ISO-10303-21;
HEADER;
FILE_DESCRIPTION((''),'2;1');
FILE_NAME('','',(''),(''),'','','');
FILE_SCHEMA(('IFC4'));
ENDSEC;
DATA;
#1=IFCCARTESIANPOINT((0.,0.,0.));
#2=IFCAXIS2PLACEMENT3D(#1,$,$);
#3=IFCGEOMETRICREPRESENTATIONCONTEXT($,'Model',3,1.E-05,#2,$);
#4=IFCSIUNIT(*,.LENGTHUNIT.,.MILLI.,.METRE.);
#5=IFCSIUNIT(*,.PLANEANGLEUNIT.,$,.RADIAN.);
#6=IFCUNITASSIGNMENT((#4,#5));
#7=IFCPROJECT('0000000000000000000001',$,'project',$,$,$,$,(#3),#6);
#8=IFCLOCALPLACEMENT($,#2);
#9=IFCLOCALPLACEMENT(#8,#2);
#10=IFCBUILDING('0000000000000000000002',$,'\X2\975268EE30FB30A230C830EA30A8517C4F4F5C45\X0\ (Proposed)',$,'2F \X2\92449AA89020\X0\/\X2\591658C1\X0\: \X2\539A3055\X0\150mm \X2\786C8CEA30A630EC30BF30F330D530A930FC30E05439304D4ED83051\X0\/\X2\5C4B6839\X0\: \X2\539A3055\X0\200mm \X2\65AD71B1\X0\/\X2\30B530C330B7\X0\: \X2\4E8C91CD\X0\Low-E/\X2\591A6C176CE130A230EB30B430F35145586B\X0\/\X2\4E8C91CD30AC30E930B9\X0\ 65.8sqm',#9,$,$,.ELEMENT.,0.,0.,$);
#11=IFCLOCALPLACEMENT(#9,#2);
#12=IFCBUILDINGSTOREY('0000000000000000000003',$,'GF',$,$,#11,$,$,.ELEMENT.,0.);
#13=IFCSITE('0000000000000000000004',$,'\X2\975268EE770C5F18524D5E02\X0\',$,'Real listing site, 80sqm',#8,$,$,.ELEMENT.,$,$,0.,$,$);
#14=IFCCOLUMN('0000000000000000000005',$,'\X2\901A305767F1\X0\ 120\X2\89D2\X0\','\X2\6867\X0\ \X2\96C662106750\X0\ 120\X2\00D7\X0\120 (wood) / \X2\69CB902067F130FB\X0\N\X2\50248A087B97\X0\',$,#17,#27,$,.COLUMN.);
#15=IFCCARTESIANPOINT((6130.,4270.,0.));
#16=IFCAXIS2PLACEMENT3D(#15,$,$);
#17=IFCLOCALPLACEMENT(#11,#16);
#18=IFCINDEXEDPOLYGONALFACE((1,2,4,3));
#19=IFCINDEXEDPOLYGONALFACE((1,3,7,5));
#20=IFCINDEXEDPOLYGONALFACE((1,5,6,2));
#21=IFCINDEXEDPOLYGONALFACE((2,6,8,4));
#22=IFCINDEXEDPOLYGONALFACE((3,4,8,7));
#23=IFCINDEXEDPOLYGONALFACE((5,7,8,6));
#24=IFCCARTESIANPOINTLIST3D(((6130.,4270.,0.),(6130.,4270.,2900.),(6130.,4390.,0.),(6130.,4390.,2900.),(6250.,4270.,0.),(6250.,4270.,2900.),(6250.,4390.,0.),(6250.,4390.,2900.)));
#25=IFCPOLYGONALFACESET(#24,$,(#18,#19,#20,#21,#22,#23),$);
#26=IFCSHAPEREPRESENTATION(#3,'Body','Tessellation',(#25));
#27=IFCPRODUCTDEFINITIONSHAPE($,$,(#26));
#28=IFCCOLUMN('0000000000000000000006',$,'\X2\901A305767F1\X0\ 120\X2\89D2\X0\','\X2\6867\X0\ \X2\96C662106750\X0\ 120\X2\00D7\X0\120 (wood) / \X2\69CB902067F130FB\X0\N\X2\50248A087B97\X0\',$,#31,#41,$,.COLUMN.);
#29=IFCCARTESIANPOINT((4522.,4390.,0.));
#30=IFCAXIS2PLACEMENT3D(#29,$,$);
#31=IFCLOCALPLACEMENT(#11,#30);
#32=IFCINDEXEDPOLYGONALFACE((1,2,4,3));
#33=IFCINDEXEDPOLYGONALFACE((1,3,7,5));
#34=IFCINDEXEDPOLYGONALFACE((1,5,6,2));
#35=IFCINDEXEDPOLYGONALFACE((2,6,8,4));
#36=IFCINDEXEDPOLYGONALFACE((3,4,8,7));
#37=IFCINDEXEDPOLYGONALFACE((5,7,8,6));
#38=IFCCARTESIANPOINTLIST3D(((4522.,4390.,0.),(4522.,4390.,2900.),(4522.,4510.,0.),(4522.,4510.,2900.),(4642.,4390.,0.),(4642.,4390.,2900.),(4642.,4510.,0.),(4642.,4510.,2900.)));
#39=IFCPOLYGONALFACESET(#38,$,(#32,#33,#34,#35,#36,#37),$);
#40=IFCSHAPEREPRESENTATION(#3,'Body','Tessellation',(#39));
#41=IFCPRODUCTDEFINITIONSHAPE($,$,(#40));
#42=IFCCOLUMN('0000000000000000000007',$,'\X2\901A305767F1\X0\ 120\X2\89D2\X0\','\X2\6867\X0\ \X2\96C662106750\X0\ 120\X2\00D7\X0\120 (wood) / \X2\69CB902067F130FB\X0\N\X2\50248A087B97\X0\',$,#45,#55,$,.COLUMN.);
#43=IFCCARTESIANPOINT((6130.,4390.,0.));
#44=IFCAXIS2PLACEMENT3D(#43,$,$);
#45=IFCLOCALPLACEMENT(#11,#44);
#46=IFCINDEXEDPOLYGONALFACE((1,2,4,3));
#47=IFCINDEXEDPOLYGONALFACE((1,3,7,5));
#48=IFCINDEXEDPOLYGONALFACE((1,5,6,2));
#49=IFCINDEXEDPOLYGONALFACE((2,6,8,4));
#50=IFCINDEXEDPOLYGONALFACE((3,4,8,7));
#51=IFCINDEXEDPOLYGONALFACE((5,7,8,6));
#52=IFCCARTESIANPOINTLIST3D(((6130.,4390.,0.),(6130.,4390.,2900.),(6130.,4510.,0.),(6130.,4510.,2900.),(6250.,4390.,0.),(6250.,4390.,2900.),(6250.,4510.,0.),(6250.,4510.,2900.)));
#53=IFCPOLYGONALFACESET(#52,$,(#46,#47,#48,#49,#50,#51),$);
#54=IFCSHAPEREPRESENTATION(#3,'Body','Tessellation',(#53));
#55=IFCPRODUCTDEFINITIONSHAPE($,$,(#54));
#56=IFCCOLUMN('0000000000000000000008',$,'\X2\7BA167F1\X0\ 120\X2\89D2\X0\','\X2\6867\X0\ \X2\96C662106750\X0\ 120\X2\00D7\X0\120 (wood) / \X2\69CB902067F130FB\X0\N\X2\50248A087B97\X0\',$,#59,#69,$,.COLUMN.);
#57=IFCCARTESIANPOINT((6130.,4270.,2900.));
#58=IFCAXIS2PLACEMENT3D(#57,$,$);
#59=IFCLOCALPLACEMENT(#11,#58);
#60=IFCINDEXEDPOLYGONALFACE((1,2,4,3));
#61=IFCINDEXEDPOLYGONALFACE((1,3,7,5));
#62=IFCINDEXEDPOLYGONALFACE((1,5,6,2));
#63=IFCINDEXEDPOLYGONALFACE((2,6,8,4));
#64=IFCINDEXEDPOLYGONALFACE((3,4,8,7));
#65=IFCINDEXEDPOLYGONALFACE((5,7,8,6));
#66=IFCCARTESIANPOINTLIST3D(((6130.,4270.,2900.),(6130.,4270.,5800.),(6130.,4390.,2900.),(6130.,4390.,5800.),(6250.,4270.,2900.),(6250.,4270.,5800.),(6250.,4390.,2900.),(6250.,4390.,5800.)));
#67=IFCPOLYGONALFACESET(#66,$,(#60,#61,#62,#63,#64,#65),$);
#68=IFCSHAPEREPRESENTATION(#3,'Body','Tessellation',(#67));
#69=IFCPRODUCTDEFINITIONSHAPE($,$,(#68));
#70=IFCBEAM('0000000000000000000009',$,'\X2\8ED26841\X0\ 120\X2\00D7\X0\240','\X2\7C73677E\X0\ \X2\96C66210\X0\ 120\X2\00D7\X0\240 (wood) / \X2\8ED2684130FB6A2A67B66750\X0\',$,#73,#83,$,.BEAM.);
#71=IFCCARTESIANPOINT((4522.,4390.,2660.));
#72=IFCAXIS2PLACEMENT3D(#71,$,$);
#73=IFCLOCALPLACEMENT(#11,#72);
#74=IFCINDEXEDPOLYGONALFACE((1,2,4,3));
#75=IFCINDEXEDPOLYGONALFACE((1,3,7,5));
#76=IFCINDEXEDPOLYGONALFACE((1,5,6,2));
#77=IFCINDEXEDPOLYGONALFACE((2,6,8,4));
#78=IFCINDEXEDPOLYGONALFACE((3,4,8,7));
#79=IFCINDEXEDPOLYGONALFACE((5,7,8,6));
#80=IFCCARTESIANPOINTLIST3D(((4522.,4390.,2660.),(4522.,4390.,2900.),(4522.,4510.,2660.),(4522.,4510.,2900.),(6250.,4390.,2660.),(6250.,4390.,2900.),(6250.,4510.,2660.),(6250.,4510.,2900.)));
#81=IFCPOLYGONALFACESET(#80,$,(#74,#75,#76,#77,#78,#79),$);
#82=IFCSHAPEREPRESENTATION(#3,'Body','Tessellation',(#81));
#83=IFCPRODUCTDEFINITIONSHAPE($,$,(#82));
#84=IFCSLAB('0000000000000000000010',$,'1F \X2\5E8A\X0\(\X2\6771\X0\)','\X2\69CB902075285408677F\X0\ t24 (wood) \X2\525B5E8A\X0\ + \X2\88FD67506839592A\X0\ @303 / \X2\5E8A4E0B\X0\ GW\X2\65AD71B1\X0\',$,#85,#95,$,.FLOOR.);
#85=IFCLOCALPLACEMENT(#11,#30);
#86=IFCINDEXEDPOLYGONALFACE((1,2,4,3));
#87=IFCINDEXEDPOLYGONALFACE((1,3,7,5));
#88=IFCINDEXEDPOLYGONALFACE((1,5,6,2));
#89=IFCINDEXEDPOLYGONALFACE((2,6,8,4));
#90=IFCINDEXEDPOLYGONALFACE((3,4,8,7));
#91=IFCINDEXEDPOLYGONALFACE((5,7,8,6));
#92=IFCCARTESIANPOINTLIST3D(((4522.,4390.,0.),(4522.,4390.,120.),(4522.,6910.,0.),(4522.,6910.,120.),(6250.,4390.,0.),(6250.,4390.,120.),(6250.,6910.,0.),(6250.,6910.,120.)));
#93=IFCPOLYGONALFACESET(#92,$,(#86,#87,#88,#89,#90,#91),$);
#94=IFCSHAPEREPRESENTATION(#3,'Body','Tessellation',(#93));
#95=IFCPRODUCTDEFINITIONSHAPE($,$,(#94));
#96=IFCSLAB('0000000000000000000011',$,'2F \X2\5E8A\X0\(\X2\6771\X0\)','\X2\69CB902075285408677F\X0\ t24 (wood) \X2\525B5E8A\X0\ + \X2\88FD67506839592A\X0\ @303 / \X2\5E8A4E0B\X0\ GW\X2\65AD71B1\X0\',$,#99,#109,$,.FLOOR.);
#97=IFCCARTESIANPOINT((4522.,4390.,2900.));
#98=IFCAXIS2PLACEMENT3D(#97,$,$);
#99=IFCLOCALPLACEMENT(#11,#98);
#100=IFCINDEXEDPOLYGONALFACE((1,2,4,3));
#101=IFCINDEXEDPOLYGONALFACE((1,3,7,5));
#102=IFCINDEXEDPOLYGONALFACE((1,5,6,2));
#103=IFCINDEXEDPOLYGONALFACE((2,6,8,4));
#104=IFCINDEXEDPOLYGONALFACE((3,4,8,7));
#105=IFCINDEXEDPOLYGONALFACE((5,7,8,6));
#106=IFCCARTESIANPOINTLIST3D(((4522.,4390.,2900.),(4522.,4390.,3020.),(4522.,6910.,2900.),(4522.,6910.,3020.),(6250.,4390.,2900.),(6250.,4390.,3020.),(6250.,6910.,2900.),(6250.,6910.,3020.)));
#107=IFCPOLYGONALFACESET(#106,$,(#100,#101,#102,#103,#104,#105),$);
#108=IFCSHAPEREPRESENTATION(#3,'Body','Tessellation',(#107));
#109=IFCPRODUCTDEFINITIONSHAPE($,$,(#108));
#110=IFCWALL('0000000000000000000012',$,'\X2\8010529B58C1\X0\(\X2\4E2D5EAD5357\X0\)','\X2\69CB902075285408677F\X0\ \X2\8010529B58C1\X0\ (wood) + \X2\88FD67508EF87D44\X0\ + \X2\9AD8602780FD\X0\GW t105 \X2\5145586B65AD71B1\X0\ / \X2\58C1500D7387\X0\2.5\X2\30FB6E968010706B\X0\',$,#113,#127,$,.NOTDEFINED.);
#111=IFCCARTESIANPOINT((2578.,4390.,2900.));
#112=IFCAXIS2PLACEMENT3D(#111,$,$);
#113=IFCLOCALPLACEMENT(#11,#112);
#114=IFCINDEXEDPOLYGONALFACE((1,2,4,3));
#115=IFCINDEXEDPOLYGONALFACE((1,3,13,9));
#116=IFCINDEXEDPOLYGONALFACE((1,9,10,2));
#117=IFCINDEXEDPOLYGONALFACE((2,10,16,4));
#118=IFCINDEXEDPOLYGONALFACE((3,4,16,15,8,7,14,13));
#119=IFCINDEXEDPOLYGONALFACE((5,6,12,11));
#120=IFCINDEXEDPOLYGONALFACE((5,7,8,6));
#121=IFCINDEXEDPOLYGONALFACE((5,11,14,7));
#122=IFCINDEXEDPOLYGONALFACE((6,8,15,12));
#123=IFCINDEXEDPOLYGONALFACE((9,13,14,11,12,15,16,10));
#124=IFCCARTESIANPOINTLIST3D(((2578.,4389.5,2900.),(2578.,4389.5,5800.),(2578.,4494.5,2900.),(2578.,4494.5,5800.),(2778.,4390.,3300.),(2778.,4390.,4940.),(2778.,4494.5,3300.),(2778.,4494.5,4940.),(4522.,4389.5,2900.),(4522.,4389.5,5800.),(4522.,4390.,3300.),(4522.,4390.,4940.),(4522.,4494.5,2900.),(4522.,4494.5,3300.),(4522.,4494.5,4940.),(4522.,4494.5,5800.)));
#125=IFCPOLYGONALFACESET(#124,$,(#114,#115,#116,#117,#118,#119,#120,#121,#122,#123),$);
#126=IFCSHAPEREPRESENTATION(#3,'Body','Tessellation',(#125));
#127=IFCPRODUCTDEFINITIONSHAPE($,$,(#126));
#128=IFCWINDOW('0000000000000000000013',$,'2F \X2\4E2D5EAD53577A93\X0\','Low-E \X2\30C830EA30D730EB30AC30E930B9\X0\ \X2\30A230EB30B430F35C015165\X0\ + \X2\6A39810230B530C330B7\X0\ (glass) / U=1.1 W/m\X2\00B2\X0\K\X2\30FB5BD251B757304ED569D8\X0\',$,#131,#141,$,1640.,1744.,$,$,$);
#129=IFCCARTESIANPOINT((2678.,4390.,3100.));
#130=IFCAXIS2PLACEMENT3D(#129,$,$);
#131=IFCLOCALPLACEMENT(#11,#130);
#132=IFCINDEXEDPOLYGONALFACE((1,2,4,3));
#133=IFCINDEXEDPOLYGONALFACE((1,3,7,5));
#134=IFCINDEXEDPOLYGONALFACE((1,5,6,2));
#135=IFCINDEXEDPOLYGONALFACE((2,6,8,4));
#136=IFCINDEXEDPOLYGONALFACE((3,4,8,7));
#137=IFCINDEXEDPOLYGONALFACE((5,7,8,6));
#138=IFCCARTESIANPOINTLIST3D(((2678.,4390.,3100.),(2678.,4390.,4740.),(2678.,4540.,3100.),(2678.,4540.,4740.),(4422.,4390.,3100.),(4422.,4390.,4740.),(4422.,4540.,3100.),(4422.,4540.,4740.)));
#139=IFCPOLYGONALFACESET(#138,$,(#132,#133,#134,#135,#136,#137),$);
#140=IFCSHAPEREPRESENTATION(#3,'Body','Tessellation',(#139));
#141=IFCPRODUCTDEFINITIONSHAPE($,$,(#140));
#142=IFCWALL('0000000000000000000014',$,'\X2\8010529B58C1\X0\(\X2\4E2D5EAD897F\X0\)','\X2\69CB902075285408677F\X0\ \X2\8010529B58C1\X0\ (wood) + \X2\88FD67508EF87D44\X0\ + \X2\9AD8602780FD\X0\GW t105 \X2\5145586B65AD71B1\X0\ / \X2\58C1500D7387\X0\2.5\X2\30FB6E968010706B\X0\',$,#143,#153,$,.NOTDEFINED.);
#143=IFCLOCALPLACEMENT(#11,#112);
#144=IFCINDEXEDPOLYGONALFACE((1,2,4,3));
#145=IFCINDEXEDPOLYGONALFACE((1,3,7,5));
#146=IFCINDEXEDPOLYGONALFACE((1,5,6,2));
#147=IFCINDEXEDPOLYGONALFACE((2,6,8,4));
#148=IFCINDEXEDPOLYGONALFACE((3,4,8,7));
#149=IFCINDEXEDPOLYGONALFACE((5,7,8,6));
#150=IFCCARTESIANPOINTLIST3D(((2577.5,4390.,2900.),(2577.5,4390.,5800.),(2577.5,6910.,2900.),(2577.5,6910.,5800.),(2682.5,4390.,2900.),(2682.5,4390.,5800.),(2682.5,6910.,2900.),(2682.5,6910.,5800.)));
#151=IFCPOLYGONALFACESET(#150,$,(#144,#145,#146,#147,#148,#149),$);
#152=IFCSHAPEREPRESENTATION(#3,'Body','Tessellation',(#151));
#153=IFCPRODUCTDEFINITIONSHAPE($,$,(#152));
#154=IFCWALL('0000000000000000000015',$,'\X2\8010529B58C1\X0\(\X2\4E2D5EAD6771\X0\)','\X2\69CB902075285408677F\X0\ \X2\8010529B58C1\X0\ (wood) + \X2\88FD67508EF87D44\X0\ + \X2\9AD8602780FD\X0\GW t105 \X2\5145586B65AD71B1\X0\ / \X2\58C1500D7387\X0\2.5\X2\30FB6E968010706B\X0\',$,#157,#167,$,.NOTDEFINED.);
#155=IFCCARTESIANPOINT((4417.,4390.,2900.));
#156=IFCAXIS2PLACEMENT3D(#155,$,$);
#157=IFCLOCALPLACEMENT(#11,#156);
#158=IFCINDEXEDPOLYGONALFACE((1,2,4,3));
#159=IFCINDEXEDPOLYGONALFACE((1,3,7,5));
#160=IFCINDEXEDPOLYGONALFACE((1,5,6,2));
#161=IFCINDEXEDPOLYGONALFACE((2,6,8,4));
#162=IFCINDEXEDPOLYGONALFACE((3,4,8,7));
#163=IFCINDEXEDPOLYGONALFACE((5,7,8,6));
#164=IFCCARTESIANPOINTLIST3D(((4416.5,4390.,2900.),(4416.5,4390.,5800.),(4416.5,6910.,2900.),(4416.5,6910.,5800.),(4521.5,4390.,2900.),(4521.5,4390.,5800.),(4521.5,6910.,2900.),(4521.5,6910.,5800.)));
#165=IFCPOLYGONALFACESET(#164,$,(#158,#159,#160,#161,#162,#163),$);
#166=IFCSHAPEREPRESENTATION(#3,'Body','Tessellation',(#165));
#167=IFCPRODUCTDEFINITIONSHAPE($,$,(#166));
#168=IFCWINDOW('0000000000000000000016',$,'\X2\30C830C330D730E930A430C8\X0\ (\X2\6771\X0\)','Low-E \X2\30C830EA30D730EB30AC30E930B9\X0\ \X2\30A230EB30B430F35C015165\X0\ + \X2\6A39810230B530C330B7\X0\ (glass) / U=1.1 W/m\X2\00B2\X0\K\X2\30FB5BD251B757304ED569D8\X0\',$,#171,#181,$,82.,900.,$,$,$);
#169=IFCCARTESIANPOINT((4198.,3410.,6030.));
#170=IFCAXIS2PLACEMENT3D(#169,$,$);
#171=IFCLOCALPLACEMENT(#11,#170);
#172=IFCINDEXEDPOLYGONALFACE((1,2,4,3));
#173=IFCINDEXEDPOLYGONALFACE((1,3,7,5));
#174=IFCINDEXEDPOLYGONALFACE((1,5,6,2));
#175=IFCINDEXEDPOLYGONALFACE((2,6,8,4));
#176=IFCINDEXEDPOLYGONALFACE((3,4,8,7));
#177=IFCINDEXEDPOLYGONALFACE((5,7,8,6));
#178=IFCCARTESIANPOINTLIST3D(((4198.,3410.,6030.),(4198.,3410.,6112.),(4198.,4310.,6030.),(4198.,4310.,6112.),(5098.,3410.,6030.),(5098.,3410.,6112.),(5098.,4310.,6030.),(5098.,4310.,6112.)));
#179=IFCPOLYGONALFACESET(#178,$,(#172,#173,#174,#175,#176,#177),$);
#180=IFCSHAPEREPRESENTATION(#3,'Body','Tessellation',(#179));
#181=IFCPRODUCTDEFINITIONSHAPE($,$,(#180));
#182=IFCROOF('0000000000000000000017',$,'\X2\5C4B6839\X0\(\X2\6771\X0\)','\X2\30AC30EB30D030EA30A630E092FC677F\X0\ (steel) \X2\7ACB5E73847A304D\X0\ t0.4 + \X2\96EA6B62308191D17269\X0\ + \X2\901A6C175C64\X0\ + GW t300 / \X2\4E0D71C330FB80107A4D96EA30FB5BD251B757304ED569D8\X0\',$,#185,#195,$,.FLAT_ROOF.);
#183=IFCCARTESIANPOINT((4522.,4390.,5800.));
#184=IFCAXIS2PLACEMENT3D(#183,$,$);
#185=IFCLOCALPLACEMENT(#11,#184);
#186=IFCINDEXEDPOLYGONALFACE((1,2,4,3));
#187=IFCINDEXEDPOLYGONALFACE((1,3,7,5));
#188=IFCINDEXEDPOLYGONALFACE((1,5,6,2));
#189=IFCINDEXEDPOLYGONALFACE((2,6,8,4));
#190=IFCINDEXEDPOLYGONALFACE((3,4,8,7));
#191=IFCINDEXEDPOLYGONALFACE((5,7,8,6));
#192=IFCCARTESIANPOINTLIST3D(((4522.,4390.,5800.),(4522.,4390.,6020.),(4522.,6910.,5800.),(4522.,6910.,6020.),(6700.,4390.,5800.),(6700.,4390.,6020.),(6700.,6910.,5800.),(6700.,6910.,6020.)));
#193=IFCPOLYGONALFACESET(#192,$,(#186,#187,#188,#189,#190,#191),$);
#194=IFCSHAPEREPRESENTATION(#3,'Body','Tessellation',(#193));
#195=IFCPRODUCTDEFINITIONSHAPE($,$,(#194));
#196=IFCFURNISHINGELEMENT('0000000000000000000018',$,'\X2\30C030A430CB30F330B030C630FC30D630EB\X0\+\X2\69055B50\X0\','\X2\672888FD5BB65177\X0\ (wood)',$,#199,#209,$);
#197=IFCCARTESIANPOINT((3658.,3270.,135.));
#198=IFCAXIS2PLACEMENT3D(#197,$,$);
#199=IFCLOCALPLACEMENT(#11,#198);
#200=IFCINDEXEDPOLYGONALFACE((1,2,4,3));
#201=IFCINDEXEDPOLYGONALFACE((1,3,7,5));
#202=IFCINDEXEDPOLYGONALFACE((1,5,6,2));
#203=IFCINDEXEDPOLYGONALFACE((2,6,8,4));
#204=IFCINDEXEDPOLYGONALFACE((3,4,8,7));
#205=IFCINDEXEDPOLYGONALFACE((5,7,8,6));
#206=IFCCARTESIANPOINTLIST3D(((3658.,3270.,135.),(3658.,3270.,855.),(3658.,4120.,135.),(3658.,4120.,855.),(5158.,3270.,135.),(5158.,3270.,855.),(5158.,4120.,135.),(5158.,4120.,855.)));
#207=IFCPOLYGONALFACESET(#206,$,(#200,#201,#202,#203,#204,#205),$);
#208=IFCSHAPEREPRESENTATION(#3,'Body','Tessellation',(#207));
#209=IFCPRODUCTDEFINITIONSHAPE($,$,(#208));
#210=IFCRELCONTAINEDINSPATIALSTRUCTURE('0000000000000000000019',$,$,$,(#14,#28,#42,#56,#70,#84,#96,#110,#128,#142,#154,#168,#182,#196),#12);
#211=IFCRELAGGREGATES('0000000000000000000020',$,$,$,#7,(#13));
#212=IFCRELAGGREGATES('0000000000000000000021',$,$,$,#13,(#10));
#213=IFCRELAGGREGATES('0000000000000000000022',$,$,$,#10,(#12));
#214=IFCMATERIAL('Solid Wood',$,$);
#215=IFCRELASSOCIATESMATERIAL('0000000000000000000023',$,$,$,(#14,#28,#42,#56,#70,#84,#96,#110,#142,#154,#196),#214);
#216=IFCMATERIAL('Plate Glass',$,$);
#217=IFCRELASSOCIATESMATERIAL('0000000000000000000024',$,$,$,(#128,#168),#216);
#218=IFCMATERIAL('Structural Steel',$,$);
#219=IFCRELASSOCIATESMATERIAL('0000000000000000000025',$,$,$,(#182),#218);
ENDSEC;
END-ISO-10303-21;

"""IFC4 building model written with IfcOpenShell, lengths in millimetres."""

from ifc_helpers import new_model, si_unit, frame, frame_2d, origin, place, context, project, spatial, rectangle, extrude, material, element, fill, save


model = new_model("IFC4")

# Units and contexts
model_context = context("Model", 3, precision=1e-05, world=origin())
ifc_project = project(units=[si_unit("LENGTHUNIT", "METRE", prefix="MILLI"), si_unit("PLANEANGLEUNIT", "RADIAN")], contexts=[model_context])

# Site, building, storey
site_placement = place(None, origin())
site = spatial("IfcSite", under=ifc_project, at=site_placement, Name="青森県弘前市", ObjectType="Real listing site, 80sqm", CompositionType="ELEMENT", RefElevation=0.0)
building_placement = place(site_placement, origin())
building = spatial("IfcBuilding", under=site, at=building_placement, Name="青森・アトリエ兼住居 (Proposed)", ObjectType="2F 鉄骨造/外壁: 厚さ150mm 硬質ウレタンフォーム吹き付け/屋根: 厚さ200mm 断熱/サッシ: 二重Low-E/多気泡アルゴン充填/二重ガラス 65.8sqm", CompositionType="ELEMENT", ElevationOfRefHeight=0.0, ElevationOfTerrain=0.0)
storey_placement = place(building_placement, origin())
storey = spatial("IfcBuildingStorey", under=building, at=storey_placement, Name="GF", CompositionType="ELEMENT", Elevation=0.0)

# Columns
ifc_material_1 = material(Name="Solid Wood")
column_1_placement = place(storey_placement, frame((6130.0, 4270.0, 0.0)))
element("IfcColumn", 1, at=column_1_placement, inside=storey, material=ifc_material_1, Name="通し柱 120角", Description="桧 集成材 120×120 (wood) / 構造柱・N値計算", PredefinedType="COLUMN", context=model_context, shape_type="SweptSolid", body=[
    extrude(rectangle(XDim=120.0, YDim=120.0, at=frame_2d((60.0, 60.0))), frame((6130.0, 4270.0, 0.0)), (0.0, 0.0, 1.0), 2900.0),
])
column_2_placement = place(storey_placement, frame((4522.0, 4390.0, 0.0)))
element("IfcColumn", 2, at=column_2_placement, inside=storey, material=ifc_material_1, Name="通し柱 120角", Description="桧 集成材 120×120 (wood) / 構造柱・N値計算", PredefinedType="COLUMN", context=model_context, shape_type="SweptSolid", body=[
    extrude(rectangle(XDim=120.0, YDim=120.0, at=frame_2d((60.0, 60.0))), frame((4522.0, 4390.0, 0.0)), (0.0, 0.0, 1.0), 2900.0),
])
column_3_placement = place(storey_placement, frame((6130.0, 4390.0, 0.0)))
element("IfcColumn", 3, at=column_3_placement, inside=storey, material=ifc_material_1, Name="通し柱 120角", Description="桧 集成材 120×120 (wood) / 構造柱・N値計算", PredefinedType="COLUMN", context=model_context, shape_type="SweptSolid", body=[
    extrude(rectangle(XDim=120.0, YDim=120.0, at=frame_2d((60.0, 60.0))), frame((6130.0, 4390.0, 0.0)), (0.0, 0.0, 1.0), 2900.0),
])
column_4_placement = place(storey_placement, frame((6130.0, 4270.0, 2900.0)))
element("IfcColumn", 4, at=column_4_placement, inside=storey, material=ifc_material_1, Name="管柱 120角", Description="桧 集成材 120×120 (wood) / 構造柱・N値計算", PredefinedType="COLUMN", context=model_context, shape_type="SweptSolid", body=[
    extrude(rectangle(XDim=120.0, YDim=120.0, at=frame_2d((60.0, 60.0))), frame((6130.0, 4270.0, 2900.0)), (0.0, 0.0, 1.0), 2900.0),
])

# Beam
beam_1_placement = place(storey_placement, frame((4522.0, 4390.0, 2660.0)))
element("IfcBeam", 5, at=beam_1_placement, inside=storey, material=ifc_material_1, Name="軒桁 120×240", Description="米松 集成 120×240 (wood) / 軒桁・横架材", PredefinedType="BEAM", context=model_context, shape_type="SweptSolid", body=[
    extrude(rectangle(XDim=1728.0, YDim=120.0, at=frame_2d((864.0, 60.0))), frame((4522.0, 4390.0, 2660.0)), (0.0, 0.0, 1.0), 240.0),
])

# Slabs
slab_1_placement = place(storey_placement, frame((4522.0, 4390.0, 0.0)))
element("IfcSlab", 6, at=slab_1_placement, inside=storey, material=ifc_material_1, Name="1F 床(東)", Description="構造用合板 t24 (wood) 剛床 + 製材根太 @303 / 床下 GW断熱", PredefinedType="FLOOR", context=model_context, shape_type="SweptSolid", body=[
    extrude(rectangle(XDim=1728.0, YDim=2520.0, at=frame_2d((864.0, 1260.0))), frame((4522.0, 4390.0, 0.0)), (0.0, 0.0, 1.0), 120.0),
])
slab_2_placement = place(storey_placement, frame((4522.0, 4390.0, 2900.0)))
element("IfcSlab", 7, at=slab_2_placement, inside=storey, material=ifc_material_1, Name="2F 床(東)", Description="構造用合板 t24 (wood) 剛床 + 製材根太 @303 / 床下 GW断熱", PredefinedType="FLOOR", context=model_context, shape_type="SweptSolid", body=[
    extrude(rectangle(XDim=1728.0, YDim=2520.0, at=frame_2d((864.0, 1260.0))), frame((4522.0, 4390.0, 2900.0)), (0.0, 0.0, 1.0), 120.0),
])

# Wall, opening, window
wall_1_placement = place(storey_placement, frame((2578.0, 4390.0, 2900.0)))
wall_1 = element("IfcWall", 8, at=wall_1_placement, inside=storey, material=ifc_material_1, Name="耐力壁(中庭南)", Description="構造用合板 耐力壁 (wood) + 製材軸組 + 高性能GW t105 充填断熱 / 壁倍率2.5・準耐火", PredefinedType="NOTDEFINED", context=model_context, shape_type="SweptSolid", body=[
    extrude(rectangle(XDim=1944.0, YDim=105.0, at=frame_2d((972.0, 52.0))), frame((2578.0, 4390.0, 2900.0)), (0.0, 0.0, 1.0), 2900.0),
])
opening_placement = place(storey_placement, frame((2678.0, 4390.0, 3100.0)))
opening = element("IfcOpeningElement", 9, at=opening_placement, cuts=wall_1, PredefinedType="NOTDEFINED", context=model_context, shape_type="SweptSolid", body=[
    extrude(rectangle(XDim=1744.0, YDim=150.0, at=frame_2d((872.0, 75.0))), frame((2678.0, 4390.0, 3100.0)), (0.0, 0.0, 1.0), 1640.0),
])
ifc_material_2 = material(Name="Plate Glass")
window_1_placement = place(storey_placement, frame((2678.0, 4390.0, 3100.0)))
window_1 = element("IfcWindow", 10, at=window_1_placement, inside=storey, material=ifc_material_2, Name="2F 中庭南窓", Description="Low-E トリプルガラス アルゴン封入 + 樹脂サッシ (glass) / U=1.1 W/m²K・寒冷地仕様", OverallHeight=1640.0, OverallWidth=1744.0, context=model_context, shape_type="SweptSolid", body=[
    extrude(rectangle(XDim=1744.0, YDim=150.0, at=frame_2d((872.0, 75.0))), frame((2678.0, 4390.0, 3100.0)), (0.0, 0.0, 1.0), 1640.0),
])
fill(opening, window_1)

# Walls
wall_2_placement = place(storey_placement, frame((2578.0, 4390.0, 2900.0)))
element("IfcWall", 11, at=wall_2_placement, inside=storey, material=ifc_material_1, Name="耐力壁(中庭西)", Description="構造用合板 耐力壁 (wood) + 製材軸組 + 高性能GW t105 充填断熱 / 壁倍率2.5・準耐火", PredefinedType="NOTDEFINED", context=model_context, shape_type="SweptSolid", body=[
    extrude(rectangle(XDim=105.0, YDim=2520.0, at=frame_2d((52.0, 1260.0))), frame((2578.0, 4390.0, 2900.0)), (0.0, 0.0, 1.0), 2900.0),
])
wall_3_placement = place(storey_placement, frame((4417.0, 4390.0, 2900.0)))
element("IfcWall", 12, at=wall_3_placement, inside=storey, material=ifc_material_1, Name="耐力壁(中庭東)", Description="構造用合板 耐力壁 (wood) + 製材軸組 + 高性能GW t105 充填断熱 / 壁倍率2.5・準耐火", PredefinedType="NOTDEFINED", context=model_context, shape_type="SweptSolid", body=[
    extrude(rectangle(XDim=105.0, YDim=2520.0, at=frame_2d((52.0, 1260.0))), frame((4417.0, 4390.0, 2900.0)), (0.0, 0.0, 1.0), 2900.0),
])

# Window
window_2_placement = place(storey_placement, frame((4198.0, 3410.0, 6030.0)))
element("IfcWindow", 13, at=window_2_placement, inside=storey, material=ifc_material_2, Name="トップライト (東)", Description="Low-E トリプルガラス アルゴン封入 + 樹脂サッシ (glass) / U=1.1 W/m²K・寒冷地仕様", OverallHeight=82.0, OverallWidth=900.0, context=model_context, shape_type="SweptSolid", body=[
    extrude(rectangle(XDim=900.0, YDim=900.0, at=frame_2d((450.0, 450.0))), frame((4198.0, 3410.0, 6030.0)), (0.0, 0.0, 1.0), 82.0),
])

# Roof
ifc_material_3 = material(Name="Structural Steel")
for number, where, name in (
    (14, (4522.0, 4390.0, 5800.0), "屋根(東)"),
):
    element("IfcRoof", number, at=place(storey_placement, frame(where)), inside=storey, material=ifc_material_3, Name=name, Description="ガルバリウム鋼板 (steel) 立平葺き t0.4 + 雪止め金物 + 通気層 + GW t300 / 不燃・耐積雪・寒冷地仕様", PredefinedType="FLAT_ROOF", context=model_context, shape_type="SweptSolid", body=[
        extrude(rectangle(XDim=2178.0, YDim=2520.0, at=frame_2d((1089.0, 1260.0))), frame((4522.0, 4390.0, 5800.0)), (0.0, 0.0, 1.0), 220.0),
    ])

# Furnishing element
furnishing_1_placement = place(storey_placement, frame((3658.0, 3270.0, 135.0)))
element("IfcFurnishingElement", 15, at=furnishing_1_placement, inside=storey, material=ifc_material_1, Name="ダイニングテーブル+椅子", Description="木製家具 (wood)", context=model_context, shape_type="SweptSolid", body=[
    extrude(rectangle(XDim=1500.0, YDim=850.0, at=frame_2d((750.0, 425.0))), frame((3658.0, 3270.0, 135.0)), (0.0, 0.0, 1.0), 720.0),
])

save(model, "model.ifc")
